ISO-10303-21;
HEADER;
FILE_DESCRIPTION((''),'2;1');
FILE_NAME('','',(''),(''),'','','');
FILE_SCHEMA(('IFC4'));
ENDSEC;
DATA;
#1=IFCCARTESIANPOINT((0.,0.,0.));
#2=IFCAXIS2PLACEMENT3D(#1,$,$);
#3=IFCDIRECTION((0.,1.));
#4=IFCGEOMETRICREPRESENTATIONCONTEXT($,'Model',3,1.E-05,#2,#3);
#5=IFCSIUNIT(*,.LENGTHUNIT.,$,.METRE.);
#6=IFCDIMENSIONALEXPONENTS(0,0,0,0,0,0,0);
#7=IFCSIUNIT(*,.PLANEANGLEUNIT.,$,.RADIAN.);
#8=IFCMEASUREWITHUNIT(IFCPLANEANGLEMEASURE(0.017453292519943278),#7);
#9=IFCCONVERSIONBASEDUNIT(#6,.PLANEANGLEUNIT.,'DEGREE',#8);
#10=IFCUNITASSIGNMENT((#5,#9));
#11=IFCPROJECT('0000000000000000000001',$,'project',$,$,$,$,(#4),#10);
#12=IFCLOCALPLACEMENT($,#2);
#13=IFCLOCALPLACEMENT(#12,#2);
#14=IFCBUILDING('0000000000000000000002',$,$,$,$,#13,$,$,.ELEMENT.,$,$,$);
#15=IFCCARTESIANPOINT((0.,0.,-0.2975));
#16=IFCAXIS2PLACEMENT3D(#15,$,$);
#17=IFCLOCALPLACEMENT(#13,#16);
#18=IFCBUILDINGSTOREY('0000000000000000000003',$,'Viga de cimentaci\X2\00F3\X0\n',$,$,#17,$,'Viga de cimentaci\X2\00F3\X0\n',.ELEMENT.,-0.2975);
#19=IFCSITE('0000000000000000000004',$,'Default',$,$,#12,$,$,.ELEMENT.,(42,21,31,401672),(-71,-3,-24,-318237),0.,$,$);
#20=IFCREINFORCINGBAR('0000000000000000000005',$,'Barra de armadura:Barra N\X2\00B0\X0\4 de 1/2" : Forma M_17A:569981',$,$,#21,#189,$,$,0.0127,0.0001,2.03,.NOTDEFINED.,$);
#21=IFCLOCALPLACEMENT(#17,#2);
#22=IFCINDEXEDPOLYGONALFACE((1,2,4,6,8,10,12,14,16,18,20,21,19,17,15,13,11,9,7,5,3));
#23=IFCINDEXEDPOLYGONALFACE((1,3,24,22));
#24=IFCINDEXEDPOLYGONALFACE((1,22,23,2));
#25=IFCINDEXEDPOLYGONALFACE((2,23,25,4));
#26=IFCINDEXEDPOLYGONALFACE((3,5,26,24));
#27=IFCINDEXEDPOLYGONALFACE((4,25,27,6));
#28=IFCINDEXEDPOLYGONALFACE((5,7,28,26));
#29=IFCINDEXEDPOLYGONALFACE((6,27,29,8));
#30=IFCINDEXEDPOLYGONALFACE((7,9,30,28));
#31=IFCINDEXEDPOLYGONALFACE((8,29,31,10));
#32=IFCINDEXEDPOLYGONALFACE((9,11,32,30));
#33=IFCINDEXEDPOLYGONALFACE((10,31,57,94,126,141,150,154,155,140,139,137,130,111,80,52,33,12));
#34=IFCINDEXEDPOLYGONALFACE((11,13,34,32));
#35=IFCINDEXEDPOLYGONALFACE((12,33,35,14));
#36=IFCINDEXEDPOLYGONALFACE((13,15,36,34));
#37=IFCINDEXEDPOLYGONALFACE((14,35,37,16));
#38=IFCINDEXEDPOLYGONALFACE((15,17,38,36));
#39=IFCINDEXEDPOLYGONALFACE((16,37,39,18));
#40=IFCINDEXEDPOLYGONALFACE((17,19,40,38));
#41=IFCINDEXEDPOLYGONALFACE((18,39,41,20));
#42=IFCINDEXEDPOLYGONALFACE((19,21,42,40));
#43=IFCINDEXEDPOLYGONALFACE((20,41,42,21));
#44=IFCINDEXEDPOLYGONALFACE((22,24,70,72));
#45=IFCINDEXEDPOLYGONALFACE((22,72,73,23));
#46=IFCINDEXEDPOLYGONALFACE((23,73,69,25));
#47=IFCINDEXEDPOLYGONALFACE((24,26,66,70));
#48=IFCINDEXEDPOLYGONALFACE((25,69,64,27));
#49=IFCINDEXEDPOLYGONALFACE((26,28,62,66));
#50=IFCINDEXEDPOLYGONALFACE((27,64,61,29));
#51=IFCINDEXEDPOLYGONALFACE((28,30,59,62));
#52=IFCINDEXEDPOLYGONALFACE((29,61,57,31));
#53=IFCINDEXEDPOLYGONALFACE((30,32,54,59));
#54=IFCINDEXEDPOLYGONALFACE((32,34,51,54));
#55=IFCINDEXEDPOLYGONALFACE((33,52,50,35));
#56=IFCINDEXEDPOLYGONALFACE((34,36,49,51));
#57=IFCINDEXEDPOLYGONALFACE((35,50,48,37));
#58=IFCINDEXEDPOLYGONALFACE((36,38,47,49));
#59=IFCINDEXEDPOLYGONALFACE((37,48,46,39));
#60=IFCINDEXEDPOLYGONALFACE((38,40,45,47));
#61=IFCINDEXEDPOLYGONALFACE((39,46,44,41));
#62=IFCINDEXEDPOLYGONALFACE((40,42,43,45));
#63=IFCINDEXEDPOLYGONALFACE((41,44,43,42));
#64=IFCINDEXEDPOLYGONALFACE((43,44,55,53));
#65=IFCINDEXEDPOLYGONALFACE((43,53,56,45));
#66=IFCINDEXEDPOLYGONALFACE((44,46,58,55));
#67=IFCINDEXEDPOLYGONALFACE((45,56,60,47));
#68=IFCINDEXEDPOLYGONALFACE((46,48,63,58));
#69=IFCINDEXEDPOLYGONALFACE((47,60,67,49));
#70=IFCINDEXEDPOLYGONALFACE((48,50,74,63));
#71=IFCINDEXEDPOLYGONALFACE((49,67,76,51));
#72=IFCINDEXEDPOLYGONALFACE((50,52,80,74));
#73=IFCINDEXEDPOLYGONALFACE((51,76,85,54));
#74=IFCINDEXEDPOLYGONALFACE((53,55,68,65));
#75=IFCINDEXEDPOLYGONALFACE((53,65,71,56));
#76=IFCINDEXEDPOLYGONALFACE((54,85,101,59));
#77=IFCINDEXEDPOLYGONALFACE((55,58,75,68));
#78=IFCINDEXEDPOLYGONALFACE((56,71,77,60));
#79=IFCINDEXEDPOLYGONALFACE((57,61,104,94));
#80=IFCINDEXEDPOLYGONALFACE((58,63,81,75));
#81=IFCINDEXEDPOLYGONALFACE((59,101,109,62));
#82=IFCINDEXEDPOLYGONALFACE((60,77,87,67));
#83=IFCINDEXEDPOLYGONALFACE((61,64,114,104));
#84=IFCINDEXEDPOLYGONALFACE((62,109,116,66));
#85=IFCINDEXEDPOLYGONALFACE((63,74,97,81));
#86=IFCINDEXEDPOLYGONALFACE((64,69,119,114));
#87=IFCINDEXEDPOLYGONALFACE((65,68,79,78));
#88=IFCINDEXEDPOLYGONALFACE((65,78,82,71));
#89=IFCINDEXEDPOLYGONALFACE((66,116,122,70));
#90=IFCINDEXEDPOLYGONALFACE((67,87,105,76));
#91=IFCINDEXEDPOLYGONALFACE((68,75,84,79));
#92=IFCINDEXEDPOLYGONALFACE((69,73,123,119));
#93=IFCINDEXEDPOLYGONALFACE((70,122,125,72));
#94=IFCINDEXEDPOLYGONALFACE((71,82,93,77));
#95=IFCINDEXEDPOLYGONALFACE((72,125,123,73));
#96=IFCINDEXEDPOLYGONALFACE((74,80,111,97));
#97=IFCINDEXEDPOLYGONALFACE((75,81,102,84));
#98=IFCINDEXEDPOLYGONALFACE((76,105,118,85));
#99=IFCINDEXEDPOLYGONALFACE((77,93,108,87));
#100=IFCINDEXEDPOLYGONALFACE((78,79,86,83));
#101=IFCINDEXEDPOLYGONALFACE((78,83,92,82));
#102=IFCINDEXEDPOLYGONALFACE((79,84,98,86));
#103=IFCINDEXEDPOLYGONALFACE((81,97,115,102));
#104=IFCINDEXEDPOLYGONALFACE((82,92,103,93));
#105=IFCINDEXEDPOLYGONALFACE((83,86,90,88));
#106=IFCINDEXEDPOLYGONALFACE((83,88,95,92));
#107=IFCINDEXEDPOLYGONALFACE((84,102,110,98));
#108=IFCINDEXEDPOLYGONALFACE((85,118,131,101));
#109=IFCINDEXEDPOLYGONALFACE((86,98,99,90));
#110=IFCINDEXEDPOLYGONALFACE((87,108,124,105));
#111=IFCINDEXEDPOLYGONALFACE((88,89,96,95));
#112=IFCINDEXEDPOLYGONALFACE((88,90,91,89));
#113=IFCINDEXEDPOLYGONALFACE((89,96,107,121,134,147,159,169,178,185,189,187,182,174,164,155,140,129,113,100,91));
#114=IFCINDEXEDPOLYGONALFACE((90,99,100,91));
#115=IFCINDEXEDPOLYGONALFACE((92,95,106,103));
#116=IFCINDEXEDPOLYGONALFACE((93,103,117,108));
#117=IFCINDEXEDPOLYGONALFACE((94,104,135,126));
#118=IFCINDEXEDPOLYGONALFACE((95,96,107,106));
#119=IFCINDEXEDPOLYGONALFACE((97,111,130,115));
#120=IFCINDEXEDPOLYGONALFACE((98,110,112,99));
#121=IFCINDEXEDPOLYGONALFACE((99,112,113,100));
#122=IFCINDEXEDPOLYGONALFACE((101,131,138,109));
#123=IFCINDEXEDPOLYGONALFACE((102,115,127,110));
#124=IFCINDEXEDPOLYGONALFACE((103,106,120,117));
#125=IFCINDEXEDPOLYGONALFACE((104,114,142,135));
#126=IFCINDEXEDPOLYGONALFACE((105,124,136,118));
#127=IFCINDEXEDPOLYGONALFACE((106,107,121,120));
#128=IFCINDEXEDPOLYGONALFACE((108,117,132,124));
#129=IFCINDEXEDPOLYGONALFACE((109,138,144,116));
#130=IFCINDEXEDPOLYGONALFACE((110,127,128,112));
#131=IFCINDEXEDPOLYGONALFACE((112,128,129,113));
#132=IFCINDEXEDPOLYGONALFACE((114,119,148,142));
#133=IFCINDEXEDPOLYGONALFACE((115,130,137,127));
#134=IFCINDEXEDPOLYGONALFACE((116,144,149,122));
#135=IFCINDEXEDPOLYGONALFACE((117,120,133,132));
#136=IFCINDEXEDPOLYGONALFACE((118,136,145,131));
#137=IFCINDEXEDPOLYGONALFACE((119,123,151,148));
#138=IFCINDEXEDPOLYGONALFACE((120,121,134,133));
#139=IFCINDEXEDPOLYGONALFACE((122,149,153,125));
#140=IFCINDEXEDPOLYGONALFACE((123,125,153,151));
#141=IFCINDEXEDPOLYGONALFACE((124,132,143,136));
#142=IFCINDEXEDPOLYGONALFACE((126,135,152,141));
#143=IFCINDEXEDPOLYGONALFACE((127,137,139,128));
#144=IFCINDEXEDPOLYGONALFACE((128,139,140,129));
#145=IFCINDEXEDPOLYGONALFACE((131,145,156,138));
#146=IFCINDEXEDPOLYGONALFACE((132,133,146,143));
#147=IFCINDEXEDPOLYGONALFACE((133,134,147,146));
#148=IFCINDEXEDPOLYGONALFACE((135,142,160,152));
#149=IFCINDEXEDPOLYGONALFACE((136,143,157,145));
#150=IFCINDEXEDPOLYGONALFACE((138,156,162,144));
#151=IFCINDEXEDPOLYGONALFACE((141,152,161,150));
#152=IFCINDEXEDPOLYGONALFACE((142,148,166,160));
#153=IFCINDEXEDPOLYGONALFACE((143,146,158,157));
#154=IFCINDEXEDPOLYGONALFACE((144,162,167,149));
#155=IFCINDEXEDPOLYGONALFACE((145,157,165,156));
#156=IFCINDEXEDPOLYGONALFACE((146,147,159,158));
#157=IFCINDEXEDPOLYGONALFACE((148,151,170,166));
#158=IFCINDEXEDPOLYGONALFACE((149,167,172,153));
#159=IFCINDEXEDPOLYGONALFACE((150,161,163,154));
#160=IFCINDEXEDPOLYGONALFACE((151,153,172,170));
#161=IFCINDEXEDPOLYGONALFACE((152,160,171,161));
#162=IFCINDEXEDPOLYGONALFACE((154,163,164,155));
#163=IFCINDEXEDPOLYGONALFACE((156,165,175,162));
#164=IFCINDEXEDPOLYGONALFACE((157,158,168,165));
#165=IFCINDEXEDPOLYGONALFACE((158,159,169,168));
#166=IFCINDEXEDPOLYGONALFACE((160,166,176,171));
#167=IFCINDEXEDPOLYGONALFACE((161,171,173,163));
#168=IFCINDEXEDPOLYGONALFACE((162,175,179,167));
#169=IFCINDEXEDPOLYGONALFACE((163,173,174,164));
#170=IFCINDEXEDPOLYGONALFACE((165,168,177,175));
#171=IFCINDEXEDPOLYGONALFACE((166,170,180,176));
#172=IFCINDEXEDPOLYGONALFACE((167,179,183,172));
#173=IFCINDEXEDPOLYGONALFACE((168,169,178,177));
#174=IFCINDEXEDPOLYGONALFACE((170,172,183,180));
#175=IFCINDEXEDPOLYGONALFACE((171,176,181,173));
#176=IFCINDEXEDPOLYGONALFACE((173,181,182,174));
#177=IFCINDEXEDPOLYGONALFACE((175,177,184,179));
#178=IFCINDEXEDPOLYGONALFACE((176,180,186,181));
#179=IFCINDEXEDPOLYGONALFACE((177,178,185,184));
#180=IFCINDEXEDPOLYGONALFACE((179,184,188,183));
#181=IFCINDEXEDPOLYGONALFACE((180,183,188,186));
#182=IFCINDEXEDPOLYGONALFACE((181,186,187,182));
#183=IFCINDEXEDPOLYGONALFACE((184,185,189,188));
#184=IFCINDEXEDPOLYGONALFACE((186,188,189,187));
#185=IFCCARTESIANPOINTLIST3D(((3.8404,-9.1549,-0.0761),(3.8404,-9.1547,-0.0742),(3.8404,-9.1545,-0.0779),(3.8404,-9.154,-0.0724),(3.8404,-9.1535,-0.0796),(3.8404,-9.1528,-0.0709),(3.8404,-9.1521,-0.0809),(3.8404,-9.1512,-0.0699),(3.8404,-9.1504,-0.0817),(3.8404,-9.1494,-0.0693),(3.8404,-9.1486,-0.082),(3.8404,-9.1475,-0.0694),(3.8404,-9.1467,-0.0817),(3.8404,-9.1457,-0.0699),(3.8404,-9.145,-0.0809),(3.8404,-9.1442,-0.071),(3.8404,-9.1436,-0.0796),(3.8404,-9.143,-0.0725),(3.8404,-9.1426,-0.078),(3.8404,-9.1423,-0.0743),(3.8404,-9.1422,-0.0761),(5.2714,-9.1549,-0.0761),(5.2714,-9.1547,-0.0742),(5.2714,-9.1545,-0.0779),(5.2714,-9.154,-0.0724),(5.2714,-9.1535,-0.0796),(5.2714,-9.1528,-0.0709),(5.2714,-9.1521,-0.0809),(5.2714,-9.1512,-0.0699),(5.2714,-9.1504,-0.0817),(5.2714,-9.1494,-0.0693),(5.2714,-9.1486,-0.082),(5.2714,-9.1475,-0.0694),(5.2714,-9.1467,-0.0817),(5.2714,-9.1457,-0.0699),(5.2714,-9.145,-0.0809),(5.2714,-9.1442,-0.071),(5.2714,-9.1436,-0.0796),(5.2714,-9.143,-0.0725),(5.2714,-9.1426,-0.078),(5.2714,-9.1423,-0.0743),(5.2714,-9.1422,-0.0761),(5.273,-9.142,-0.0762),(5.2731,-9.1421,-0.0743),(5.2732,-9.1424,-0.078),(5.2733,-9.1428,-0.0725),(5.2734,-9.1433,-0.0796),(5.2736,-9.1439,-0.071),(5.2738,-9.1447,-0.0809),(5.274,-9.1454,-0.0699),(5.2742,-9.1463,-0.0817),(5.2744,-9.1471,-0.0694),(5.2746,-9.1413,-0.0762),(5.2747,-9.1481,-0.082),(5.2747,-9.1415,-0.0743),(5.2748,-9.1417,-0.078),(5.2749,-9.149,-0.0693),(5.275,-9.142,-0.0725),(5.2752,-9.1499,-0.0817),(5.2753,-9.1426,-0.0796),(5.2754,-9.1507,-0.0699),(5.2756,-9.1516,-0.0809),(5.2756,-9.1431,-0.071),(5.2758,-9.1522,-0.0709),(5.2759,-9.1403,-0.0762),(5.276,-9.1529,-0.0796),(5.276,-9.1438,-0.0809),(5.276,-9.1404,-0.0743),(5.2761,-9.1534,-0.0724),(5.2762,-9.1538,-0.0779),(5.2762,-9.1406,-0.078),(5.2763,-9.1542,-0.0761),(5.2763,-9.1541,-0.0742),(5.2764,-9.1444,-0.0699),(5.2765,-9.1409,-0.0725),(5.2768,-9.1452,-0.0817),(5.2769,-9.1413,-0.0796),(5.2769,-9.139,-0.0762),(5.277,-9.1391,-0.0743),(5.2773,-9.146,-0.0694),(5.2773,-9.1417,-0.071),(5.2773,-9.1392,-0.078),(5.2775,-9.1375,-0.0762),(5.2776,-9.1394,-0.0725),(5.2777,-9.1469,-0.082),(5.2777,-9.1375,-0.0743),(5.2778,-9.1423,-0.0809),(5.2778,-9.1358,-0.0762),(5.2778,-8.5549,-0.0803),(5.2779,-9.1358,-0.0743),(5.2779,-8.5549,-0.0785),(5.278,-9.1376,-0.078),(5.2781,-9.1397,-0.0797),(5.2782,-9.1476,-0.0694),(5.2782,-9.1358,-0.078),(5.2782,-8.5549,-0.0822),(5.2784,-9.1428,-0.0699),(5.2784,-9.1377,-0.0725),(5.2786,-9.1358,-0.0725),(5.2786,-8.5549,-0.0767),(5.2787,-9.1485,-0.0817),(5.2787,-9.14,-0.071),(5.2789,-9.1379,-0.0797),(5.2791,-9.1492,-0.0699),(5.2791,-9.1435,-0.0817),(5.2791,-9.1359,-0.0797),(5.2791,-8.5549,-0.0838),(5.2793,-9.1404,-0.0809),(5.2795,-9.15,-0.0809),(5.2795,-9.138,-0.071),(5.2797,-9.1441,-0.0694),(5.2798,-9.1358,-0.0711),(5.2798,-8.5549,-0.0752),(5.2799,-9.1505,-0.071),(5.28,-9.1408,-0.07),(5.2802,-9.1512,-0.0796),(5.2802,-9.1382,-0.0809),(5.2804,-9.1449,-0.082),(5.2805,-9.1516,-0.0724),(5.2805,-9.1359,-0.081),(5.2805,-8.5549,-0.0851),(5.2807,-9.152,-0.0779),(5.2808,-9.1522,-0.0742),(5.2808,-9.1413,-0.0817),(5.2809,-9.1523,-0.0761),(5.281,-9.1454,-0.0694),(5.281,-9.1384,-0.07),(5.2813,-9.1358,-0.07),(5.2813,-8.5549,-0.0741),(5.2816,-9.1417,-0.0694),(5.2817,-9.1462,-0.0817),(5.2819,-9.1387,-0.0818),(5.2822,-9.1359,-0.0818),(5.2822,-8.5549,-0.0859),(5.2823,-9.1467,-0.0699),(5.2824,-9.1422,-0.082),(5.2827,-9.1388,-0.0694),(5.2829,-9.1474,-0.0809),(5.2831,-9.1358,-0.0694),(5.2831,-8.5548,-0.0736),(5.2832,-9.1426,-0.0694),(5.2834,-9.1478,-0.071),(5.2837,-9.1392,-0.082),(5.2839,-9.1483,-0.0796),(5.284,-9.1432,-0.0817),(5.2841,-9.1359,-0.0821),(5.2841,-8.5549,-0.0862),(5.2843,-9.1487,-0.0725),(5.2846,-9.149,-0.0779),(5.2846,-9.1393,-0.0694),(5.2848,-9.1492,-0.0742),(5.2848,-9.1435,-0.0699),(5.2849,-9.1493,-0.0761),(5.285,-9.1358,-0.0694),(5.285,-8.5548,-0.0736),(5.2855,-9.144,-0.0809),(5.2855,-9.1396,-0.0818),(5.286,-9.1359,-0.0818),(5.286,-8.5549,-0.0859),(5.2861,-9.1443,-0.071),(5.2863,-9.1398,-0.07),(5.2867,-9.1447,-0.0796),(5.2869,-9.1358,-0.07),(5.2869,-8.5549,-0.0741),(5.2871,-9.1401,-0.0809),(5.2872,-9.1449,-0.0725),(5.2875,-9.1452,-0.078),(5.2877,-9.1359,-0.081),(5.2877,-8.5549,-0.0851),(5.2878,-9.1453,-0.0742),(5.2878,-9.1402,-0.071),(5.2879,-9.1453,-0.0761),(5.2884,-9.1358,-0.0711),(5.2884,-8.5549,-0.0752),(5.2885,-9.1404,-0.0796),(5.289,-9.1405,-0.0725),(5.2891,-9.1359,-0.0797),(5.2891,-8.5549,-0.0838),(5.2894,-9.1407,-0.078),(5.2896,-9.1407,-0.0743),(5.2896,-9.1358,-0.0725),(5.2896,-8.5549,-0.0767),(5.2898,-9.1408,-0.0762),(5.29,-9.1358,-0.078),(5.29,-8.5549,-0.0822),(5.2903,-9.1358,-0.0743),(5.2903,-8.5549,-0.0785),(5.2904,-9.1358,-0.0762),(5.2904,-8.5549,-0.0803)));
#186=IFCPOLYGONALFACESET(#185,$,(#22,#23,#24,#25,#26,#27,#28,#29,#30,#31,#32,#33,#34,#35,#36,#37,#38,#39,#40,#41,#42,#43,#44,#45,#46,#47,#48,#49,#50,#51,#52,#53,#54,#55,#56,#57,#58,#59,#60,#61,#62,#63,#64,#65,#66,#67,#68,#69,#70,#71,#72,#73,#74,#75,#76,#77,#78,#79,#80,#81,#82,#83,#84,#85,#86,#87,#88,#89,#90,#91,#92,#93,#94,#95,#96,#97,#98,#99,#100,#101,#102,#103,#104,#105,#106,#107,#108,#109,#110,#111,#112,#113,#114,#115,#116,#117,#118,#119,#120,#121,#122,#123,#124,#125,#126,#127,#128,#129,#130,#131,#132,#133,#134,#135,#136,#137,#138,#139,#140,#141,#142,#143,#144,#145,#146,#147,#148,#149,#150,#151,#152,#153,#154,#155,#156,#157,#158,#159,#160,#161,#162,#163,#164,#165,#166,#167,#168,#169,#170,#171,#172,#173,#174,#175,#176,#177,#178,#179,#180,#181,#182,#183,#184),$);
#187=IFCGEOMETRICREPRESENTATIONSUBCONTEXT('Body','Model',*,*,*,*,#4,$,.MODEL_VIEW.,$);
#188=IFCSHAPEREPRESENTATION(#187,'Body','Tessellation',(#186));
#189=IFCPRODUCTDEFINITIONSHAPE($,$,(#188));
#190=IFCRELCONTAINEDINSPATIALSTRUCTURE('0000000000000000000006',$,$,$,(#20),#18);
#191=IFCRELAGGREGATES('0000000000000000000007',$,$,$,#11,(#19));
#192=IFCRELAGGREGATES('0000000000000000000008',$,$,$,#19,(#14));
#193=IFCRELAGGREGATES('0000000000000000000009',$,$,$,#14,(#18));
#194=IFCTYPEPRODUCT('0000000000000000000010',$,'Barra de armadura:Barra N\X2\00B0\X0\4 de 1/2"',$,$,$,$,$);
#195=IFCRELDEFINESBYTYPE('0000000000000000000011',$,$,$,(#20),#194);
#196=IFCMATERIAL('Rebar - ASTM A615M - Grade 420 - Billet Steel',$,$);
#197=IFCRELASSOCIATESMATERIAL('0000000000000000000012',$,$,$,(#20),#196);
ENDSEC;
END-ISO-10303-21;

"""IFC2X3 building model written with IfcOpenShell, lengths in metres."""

from ifc_helpers import new_model, entity, si_unit, converted_unit, direction, frame, origin, place, context, subcontext, project, spatial, material, type_object, element, save


model = new_model("IFC2X3")

# Units and contexts
model_context = context("Model", 3, precision=1e-05, world=origin(), true_north=direction((0.0, 1.0)))
body_context = subcontext(model_context, "Body", "Model", "MODEL_VIEW")
ifc_project = project(units=[si_unit("LENGTHUNIT", "METRE"), converted_unit("PLANEANGLEUNIT", "DEGREE", entity("IfcPlaneAngleMeasure", 0.017453292519943278), si_unit("PLANEANGLEUNIT", "RADIAN"), dimensions=[0, 0, 0, 0, 0, 0, 0])], contexts=[model_context])

# Site, building, storey
site_placement = place(None, origin())
site = spatial("IfcSite", under=ifc_project, at=site_placement, Name="Default", CompositionType="ELEMENT", RefLatitude=(42, 21, 31, 401672), RefLongitude=(-71, -3, -24, -318237), RefElevation=0.0)
building_placement = place(site_placement, origin())
building = spatial("IfcBuilding", under=site, at=building_placement, CompositionType="ELEMENT")
storey_placement = place(building_placement, frame((0.0, 0.0, -0.2975)))
storey = spatial("IfcBuildingStorey", under=building, at=storey_placement, Name="Viga de cimentación", LongName="Viga de cimentación", CompositionType="ELEMENT", Elevation=-0.2975)

# Reinforcing bar
ifc_material = material(Name="Rebar - ASTM A615M - Grade 420 - Billet Steel")
type_product_1 = type_object("IfcTypeProduct", Name="Barra de armadura:Barra N°4 de 1/2\"")
reinforcing_bar_1_placement = place(storey_placement, origin())
element("IfcReinforcingBar", 1, at=reinforcing_bar_1_placement, inside=storey, type_object=type_product_1, material=ifc_material, Name="Barra de armadura:Barra N°4 de 1/2\" : Forma M_17A:569981", BarLength=2.03, BarRole="NOTDEFINED", CrossSectionArea=0.0001, NominalDiameter=0.0127, context=body_context, shape_type="AdvancedSweptSolid", body=[
    entity("IfcSweptDiskSolid", entity("IfcCompositeCurve", [entity("IfcCompositeCurveSegment", "CONTINUOUS", True, entity("IfcPolyline", [entity("IfcCartesianPoint", [5.2841, -8.5549, -0.0799]), entity("IfcCartesianPoint", [5.2841, -9.1358, -0.0757])])), entity("IfcCompositeCurveSegment", "CONTINUOUS", True, entity("IfcTrimmedCurve", entity("IfcCircle", entity("IfcAxis2Placement3D", entity("IfcCartesianPoint", [5.2714, -9.1358, -0.0757]), entity("IfcDirection", [0.0, -0.007141, -0.999975]), entity("IfcDirection", [0.0, -0.999975, 0.007141])), 0.0127), [entity("IfcParameterValue", 270.0)], [entity("IfcParameterValue", 360.0)], True, "PARAMETER")), entity("IfcCompositeCurveSegment", "CONTINUOUS", True, entity("IfcPolyline", [entity("IfcCartesianPoint", [5.2714, -9.1485, -0.0756]), entity("IfcCartesianPoint", [3.8404, -9.1485, -0.0756])]))], False), 0.0063, None, 0.0, 92.0),
])

save(model, "model.ifc")
